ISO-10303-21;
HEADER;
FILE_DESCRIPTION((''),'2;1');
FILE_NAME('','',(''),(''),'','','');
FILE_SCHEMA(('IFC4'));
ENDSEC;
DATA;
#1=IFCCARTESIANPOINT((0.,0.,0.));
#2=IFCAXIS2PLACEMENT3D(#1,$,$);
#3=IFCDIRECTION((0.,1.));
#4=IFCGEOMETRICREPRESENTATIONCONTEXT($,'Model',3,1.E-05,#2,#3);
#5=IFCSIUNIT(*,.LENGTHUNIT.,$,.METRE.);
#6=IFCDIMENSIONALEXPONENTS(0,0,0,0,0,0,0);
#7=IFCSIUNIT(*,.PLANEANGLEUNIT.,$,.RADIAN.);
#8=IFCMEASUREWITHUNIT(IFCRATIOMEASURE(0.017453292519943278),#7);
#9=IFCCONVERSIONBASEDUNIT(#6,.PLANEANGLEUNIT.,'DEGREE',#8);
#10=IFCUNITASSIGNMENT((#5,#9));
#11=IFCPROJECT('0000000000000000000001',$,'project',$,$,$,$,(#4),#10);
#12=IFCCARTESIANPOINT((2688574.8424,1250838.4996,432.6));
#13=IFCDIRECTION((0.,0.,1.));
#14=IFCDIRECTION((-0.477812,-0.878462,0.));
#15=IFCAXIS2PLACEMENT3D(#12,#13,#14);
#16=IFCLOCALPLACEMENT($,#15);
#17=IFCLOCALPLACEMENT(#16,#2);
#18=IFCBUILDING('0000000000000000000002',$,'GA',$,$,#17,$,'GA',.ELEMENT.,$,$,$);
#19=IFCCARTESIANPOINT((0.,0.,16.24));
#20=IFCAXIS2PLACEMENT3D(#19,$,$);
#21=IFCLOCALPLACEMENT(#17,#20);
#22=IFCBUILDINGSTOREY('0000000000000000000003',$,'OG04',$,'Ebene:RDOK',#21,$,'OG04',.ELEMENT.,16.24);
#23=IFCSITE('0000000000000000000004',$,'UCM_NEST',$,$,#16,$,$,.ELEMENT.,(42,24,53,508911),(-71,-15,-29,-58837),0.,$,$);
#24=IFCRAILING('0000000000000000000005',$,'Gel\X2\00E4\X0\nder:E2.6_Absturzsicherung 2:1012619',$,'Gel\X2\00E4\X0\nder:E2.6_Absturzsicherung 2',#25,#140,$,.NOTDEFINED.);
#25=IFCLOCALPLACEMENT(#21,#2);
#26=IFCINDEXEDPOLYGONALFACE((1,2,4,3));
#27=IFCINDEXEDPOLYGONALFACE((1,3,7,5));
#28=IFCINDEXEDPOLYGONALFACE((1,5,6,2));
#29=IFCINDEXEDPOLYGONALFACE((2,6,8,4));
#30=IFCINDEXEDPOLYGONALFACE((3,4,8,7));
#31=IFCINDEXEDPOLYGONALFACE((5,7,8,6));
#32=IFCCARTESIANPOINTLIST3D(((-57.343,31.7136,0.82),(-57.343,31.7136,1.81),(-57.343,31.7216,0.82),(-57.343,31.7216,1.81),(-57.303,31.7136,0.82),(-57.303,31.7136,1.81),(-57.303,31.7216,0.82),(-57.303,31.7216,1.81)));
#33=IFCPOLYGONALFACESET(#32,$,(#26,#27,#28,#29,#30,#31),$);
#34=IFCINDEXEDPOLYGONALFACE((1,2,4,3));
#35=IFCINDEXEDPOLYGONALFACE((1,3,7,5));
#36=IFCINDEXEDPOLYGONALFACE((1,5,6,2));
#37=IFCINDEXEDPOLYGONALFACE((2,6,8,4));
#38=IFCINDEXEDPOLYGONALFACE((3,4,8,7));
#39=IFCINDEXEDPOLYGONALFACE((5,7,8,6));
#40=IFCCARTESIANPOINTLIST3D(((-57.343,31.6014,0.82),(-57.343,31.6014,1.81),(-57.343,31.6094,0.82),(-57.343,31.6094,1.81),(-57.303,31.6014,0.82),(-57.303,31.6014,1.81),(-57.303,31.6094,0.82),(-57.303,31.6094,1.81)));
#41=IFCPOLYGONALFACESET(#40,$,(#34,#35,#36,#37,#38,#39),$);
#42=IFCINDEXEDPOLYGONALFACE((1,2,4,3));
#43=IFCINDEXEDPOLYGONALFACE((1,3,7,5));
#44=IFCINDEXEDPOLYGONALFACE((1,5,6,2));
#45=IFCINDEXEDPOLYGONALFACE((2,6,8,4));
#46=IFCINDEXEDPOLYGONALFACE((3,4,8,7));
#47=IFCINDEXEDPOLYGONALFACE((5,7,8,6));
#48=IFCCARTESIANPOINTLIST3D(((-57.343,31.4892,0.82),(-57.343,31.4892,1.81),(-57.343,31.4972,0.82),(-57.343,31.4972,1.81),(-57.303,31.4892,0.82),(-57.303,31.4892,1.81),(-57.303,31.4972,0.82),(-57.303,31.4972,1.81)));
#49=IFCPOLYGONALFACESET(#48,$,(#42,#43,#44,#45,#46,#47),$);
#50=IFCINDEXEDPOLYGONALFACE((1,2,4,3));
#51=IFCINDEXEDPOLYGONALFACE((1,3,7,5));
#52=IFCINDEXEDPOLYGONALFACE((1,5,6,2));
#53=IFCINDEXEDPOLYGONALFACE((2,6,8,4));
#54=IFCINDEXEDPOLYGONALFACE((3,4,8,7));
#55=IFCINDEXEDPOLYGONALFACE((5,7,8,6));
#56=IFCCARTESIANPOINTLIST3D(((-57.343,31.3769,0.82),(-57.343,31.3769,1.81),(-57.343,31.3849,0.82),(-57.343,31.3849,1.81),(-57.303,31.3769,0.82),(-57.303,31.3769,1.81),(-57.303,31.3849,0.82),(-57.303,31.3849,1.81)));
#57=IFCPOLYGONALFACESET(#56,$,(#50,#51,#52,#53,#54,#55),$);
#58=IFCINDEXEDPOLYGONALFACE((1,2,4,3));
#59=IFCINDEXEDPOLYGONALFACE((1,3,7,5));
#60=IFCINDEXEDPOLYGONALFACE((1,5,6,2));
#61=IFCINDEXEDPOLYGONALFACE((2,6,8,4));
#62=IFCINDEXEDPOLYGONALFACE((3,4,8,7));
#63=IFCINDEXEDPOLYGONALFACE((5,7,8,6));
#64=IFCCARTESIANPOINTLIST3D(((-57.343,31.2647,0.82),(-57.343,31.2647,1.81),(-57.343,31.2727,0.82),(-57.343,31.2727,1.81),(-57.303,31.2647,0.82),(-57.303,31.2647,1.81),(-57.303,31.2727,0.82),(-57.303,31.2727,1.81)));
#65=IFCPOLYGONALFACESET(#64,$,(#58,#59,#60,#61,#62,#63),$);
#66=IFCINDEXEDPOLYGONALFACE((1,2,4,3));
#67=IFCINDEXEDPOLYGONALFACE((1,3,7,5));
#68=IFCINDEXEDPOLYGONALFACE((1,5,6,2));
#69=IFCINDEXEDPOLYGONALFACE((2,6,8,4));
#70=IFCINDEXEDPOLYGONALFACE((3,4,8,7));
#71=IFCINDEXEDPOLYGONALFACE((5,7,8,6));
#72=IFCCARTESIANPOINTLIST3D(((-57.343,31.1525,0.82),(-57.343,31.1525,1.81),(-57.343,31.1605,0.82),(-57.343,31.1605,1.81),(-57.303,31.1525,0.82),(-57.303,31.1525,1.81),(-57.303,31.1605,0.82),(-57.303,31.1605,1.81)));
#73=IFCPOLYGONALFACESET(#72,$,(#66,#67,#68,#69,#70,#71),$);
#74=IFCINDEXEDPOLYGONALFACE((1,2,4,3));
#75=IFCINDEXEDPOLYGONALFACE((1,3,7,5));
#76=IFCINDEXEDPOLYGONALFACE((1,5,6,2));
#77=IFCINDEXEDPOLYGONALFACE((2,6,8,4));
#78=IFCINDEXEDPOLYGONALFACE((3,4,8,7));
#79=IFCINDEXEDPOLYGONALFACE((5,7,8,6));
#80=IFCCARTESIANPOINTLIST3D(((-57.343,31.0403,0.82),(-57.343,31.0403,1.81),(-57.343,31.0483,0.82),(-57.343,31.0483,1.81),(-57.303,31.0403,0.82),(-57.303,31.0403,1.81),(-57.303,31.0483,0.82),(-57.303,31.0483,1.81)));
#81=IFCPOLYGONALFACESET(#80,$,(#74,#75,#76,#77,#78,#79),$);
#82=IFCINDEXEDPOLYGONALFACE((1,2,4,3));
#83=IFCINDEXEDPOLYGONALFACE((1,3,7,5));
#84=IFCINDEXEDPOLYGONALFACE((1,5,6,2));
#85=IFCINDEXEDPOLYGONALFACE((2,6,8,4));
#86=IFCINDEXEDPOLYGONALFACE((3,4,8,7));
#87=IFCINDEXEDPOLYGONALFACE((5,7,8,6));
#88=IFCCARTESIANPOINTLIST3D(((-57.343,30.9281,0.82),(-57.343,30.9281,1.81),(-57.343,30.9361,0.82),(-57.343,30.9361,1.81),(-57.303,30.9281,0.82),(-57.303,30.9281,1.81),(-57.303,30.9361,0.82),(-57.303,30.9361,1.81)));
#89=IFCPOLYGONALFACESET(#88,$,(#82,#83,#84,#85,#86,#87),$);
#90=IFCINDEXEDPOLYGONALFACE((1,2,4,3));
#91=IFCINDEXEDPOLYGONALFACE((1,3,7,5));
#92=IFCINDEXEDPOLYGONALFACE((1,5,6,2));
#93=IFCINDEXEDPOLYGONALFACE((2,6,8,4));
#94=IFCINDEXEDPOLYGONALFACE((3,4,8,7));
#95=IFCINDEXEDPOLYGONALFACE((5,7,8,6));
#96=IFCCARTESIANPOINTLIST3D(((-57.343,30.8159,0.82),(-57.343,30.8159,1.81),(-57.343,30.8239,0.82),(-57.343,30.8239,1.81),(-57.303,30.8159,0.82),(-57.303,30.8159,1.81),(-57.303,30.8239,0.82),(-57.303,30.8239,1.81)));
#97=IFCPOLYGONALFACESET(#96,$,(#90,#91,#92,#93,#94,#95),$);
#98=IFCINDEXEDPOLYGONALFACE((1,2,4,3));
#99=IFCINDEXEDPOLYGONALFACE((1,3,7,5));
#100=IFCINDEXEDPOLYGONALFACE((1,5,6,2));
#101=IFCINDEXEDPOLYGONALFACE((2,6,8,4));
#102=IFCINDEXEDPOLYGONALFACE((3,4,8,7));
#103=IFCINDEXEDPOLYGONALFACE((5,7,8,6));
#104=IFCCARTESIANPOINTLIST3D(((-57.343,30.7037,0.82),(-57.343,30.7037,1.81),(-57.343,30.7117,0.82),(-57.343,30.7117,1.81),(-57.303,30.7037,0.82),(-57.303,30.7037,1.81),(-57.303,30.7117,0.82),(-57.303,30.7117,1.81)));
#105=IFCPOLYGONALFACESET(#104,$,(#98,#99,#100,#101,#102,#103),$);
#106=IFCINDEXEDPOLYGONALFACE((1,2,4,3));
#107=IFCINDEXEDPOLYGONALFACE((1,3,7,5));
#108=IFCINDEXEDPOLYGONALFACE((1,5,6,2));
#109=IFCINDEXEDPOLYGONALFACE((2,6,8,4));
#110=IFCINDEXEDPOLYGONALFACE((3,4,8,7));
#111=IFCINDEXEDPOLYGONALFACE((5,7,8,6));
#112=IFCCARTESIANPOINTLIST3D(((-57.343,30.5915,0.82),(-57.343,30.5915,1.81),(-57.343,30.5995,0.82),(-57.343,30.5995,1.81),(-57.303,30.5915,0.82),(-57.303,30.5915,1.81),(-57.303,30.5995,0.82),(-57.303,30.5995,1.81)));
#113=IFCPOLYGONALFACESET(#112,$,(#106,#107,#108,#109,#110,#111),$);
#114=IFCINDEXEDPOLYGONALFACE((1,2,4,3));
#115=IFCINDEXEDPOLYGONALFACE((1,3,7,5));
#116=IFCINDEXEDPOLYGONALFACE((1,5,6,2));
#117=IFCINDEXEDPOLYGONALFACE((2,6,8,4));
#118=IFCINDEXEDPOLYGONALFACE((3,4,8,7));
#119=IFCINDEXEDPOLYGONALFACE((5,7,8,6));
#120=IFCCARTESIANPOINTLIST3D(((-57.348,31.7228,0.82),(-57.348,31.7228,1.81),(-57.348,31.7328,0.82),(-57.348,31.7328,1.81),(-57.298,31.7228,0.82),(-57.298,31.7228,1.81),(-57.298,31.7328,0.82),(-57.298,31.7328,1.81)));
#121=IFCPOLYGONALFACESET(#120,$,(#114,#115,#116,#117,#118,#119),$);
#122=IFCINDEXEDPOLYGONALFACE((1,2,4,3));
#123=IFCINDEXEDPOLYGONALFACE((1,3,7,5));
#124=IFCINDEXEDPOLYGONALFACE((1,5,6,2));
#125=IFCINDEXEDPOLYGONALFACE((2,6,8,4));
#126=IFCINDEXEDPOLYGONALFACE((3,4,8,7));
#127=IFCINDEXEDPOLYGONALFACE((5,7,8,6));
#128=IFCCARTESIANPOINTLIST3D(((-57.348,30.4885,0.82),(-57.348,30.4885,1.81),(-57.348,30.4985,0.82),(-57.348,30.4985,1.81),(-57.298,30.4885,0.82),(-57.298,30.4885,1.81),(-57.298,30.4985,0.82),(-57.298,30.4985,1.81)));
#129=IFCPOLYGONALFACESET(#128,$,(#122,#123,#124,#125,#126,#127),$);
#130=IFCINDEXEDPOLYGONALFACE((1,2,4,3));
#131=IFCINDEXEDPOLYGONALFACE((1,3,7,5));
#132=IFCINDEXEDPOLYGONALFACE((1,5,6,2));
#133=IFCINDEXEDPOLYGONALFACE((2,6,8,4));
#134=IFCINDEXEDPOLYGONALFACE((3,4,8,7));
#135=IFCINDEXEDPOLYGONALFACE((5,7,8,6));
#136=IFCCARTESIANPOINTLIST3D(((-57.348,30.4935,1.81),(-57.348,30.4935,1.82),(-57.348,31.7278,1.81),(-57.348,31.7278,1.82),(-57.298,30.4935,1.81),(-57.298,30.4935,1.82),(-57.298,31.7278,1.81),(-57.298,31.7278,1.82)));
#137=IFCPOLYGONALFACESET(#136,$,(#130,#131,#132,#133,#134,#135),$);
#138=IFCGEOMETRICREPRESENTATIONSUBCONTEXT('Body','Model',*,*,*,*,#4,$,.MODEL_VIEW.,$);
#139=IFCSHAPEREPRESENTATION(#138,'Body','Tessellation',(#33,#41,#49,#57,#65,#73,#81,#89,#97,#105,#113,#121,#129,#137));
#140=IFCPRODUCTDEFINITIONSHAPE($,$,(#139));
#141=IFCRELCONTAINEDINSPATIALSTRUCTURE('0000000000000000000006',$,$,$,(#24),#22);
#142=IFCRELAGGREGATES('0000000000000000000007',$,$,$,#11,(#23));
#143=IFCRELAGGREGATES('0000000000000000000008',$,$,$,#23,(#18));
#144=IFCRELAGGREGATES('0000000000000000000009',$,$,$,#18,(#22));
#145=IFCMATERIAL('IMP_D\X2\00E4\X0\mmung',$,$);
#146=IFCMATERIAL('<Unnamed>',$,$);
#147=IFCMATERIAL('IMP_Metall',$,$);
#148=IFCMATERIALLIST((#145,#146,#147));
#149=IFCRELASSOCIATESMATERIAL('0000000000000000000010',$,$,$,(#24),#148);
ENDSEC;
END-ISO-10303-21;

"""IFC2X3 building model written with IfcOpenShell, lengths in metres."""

from ifc_helpers import new_model, entity, si_unit, converted_unit, direction, frame, frame_2d, origin, origin_2d_with_axis, place, context, subcontext, project, spatial, rectangle, extrude, material, material_list, element, save


model = new_model("IFC2X3")

# Units and contexts
model_context = context("Model", 3, precision=1e-05, world=origin(), true_north=direction((0.0, 1.0)))
body_context = subcontext(model_context, "Body", "Model", "MODEL_VIEW")
ifc_project = project(units=[si_unit("LENGTHUNIT", "METRE"), converted_unit("PLANEANGLEUNIT", "DEGREE", entity("IfcRatioMeasure", 0.017453292519943278), si_unit("PLANEANGLEUNIT", "RADIAN"), dimensions=[0, 0, 0, 0, 0, 0, 0])], contexts=[model_context])

# Site, building, storey
site_placement = place(None, frame((2688574.8424, 1250838.4996, 432.6), z_axis=(0.0, 0.0, 1.0), x_axis=(-0.477812, -0.878462, 0.0)))
site = spatial("IfcSite", under=ifc_project, at=site_placement, Name="UCM_NEST", CompositionType="ELEMENT", RefLatitude=(42, 24, 53, 508911), RefLongitude=(-71, -15, -29, -58837), RefElevation=0.0)
building_placement = place(site_placement, origin())
building = spatial("IfcBuilding", under=site, at=building_placement, Name="GA", LongName="GA", CompositionType="ELEMENT")
storey_placement = place(building_placement, frame((0.0, 0.0, 16.24)))
storey = spatial("IfcBuildingStorey", under=building, at=storey_placement, Name="OG04", ObjectType="Ebene:RDOK", LongName="OG04", CompositionType="ELEMENT", Elevation=16.24)

# Shared definitions
ifc_material_1 = material(Name="<Unnamed>")

# Shared definitions
ifc_material_2 = material(Name="IMP_Dämmung")

# Railing
ifc_material_3 = material(Name="IMP_Metall")
ifc_material_list = material_list([ifc_material_2, ifc_material_1, ifc_material_3])
railing_1_placement = place(storey_placement, origin())
element("IfcRailing", 1, at=railing_1_placement, inside=storey, material=ifc_material_list, Name="Geländer:E2.6_Absturzsicherung 2:1012619", ObjectType="Geländer:E2.6_Absturzsicherung 2", PredefinedType="NOTDEFINED", context=body_context, shape_type="SweptSolid", body=[
    extrude(rectangle(XDim=0.008, YDim=0.04, at=origin_2d_with_axis()), frame((-57.323, 31.7176, 0.82), z_axis=(0.0, 0.0, 1.0), x_axis=(0.0, 1.0, 0.0)), (0.0, 0.0, 1.0), 0.99),
    extrude(rectangle(XDim=0.008, YDim=0.04, at=origin_2d_with_axis()), frame((-57.323, 31.6054, 0.82), z_axis=(0.0, 0.0, 1.0), x_axis=(0.0, 1.0, 0.0)), (0.0, 0.0, 1.0), 0.99),
    extrude(rectangle(XDim=0.008, YDim=0.04, at=origin_2d_with_axis()), frame((-57.323, 31.4932, 0.82), z_axis=(0.0, 0.0, 1.0), x_axis=(0.0, 1.0, 0.0)), (0.0, 0.0, 1.0), 0.99),
    extrude(rectangle(XDim=0.008, YDim=0.04, at=origin_2d_with_axis()), frame((-57.323, 31.3809, 0.82), z_axis=(0.0, 0.0, 1.0), x_axis=(0.0, 1.0, 0.0)), (0.0, 0.0, 1.0), 0.99),
    extrude(rectangle(XDim=0.008, YDim=0.04, at=origin_2d_with_axis()), frame((-57.323, 31.2687, 0.82), z_axis=(0.0, 0.0, 1.0), x_axis=(0.0, 1.0, 0.0)), (0.0, 0.0, 1.0), 0.99),
    extrude(rectangle(XDim=0.008, YDim=0.04, at=origin_2d_with_axis()), frame((-57.323, 31.1565, 0.82), z_axis=(0.0, 0.0, 1.0), x_axis=(0.0, 1.0, 0.0)), (0.0, 0.0, 1.0), 0.99),
    extrude(rectangle(XDim=0.008, YDim=0.04, at=origin_2d_with_axis()), frame((-57.323, 31.0443, 0.82), z_axis=(0.0, 0.0, 1.0), x_axis=(0.0, 1.0, 0.0)), (0.0, 0.0, 1.0), 0.99),
    extrude(rectangle(XDim=0.008, YDim=0.04, at=origin_2d_with_axis()), frame((-57.323, 30.9321, 0.82), z_axis=(0.0, 0.0, 1.0), x_axis=(0.0, 1.0, 0.0)), (0.0, 0.0, 1.0), 0.99),
    extrude(rectangle(XDim=0.008, YDim=0.04, at=origin_2d_with_axis()), frame((-57.323, 30.8199, 0.82), z_axis=(0.0, 0.0, 1.0), x_axis=(0.0, 1.0, 0.0)), (0.0, 0.0, 1.0), 0.99),
    extrude(rectangle(XDim=0.008, YDim=0.04, at=origin_2d_with_axis()), frame((-57.323, 30.7077, 0.82), z_axis=(0.0, 0.0, 1.0), x_axis=(0.0, 1.0, 0.0)), (0.0, 0.0, 1.0), 0.99),
    extrude(rectangle(XDim=0.008, YDim=0.04, at=origin_2d_with_axis()), frame((-57.323, 30.5955, 0.82), z_axis=(0.0, 0.0, 1.0), x_axis=(0.0, 1.0, 0.0)), (0.0, 0.0, 1.0), 0.99),
    extrude(rectangle(XDim=0.01, YDim=0.05, at=origin_2d_with_axis()), frame((-57.323, 31.7278, 0.82), z_axis=(0.0, 0.0, 1.0), x_axis=(0.0, 1.0, 0.0)), (0.0, 0.0, 1.0), 0.99),
    extrude(rectangle(XDim=0.01, YDim=0.05, at=origin_2d_with_axis()), frame((-57.323, 30.4935, 0.82), z_axis=(0.0, 0.0, 1.0), x_axis=(0.0, 1.0, 0.0)), (0.0, 0.0, 1.0), 0.99),
    extrude(rectangle(XDim=1.2343, YDim=0.05, at=frame_2d((0.0, 0.0), x_axis=(1.0, 0.0))), frame((-57.323, 31.1106, 1.81), z_axis=(0.0, 0.0, 1.0), x_axis=(0.0, 1.0, 0.0)), (0.0, 0.0, 1.0), 0.01),
])

save(model, "model.ifc")
